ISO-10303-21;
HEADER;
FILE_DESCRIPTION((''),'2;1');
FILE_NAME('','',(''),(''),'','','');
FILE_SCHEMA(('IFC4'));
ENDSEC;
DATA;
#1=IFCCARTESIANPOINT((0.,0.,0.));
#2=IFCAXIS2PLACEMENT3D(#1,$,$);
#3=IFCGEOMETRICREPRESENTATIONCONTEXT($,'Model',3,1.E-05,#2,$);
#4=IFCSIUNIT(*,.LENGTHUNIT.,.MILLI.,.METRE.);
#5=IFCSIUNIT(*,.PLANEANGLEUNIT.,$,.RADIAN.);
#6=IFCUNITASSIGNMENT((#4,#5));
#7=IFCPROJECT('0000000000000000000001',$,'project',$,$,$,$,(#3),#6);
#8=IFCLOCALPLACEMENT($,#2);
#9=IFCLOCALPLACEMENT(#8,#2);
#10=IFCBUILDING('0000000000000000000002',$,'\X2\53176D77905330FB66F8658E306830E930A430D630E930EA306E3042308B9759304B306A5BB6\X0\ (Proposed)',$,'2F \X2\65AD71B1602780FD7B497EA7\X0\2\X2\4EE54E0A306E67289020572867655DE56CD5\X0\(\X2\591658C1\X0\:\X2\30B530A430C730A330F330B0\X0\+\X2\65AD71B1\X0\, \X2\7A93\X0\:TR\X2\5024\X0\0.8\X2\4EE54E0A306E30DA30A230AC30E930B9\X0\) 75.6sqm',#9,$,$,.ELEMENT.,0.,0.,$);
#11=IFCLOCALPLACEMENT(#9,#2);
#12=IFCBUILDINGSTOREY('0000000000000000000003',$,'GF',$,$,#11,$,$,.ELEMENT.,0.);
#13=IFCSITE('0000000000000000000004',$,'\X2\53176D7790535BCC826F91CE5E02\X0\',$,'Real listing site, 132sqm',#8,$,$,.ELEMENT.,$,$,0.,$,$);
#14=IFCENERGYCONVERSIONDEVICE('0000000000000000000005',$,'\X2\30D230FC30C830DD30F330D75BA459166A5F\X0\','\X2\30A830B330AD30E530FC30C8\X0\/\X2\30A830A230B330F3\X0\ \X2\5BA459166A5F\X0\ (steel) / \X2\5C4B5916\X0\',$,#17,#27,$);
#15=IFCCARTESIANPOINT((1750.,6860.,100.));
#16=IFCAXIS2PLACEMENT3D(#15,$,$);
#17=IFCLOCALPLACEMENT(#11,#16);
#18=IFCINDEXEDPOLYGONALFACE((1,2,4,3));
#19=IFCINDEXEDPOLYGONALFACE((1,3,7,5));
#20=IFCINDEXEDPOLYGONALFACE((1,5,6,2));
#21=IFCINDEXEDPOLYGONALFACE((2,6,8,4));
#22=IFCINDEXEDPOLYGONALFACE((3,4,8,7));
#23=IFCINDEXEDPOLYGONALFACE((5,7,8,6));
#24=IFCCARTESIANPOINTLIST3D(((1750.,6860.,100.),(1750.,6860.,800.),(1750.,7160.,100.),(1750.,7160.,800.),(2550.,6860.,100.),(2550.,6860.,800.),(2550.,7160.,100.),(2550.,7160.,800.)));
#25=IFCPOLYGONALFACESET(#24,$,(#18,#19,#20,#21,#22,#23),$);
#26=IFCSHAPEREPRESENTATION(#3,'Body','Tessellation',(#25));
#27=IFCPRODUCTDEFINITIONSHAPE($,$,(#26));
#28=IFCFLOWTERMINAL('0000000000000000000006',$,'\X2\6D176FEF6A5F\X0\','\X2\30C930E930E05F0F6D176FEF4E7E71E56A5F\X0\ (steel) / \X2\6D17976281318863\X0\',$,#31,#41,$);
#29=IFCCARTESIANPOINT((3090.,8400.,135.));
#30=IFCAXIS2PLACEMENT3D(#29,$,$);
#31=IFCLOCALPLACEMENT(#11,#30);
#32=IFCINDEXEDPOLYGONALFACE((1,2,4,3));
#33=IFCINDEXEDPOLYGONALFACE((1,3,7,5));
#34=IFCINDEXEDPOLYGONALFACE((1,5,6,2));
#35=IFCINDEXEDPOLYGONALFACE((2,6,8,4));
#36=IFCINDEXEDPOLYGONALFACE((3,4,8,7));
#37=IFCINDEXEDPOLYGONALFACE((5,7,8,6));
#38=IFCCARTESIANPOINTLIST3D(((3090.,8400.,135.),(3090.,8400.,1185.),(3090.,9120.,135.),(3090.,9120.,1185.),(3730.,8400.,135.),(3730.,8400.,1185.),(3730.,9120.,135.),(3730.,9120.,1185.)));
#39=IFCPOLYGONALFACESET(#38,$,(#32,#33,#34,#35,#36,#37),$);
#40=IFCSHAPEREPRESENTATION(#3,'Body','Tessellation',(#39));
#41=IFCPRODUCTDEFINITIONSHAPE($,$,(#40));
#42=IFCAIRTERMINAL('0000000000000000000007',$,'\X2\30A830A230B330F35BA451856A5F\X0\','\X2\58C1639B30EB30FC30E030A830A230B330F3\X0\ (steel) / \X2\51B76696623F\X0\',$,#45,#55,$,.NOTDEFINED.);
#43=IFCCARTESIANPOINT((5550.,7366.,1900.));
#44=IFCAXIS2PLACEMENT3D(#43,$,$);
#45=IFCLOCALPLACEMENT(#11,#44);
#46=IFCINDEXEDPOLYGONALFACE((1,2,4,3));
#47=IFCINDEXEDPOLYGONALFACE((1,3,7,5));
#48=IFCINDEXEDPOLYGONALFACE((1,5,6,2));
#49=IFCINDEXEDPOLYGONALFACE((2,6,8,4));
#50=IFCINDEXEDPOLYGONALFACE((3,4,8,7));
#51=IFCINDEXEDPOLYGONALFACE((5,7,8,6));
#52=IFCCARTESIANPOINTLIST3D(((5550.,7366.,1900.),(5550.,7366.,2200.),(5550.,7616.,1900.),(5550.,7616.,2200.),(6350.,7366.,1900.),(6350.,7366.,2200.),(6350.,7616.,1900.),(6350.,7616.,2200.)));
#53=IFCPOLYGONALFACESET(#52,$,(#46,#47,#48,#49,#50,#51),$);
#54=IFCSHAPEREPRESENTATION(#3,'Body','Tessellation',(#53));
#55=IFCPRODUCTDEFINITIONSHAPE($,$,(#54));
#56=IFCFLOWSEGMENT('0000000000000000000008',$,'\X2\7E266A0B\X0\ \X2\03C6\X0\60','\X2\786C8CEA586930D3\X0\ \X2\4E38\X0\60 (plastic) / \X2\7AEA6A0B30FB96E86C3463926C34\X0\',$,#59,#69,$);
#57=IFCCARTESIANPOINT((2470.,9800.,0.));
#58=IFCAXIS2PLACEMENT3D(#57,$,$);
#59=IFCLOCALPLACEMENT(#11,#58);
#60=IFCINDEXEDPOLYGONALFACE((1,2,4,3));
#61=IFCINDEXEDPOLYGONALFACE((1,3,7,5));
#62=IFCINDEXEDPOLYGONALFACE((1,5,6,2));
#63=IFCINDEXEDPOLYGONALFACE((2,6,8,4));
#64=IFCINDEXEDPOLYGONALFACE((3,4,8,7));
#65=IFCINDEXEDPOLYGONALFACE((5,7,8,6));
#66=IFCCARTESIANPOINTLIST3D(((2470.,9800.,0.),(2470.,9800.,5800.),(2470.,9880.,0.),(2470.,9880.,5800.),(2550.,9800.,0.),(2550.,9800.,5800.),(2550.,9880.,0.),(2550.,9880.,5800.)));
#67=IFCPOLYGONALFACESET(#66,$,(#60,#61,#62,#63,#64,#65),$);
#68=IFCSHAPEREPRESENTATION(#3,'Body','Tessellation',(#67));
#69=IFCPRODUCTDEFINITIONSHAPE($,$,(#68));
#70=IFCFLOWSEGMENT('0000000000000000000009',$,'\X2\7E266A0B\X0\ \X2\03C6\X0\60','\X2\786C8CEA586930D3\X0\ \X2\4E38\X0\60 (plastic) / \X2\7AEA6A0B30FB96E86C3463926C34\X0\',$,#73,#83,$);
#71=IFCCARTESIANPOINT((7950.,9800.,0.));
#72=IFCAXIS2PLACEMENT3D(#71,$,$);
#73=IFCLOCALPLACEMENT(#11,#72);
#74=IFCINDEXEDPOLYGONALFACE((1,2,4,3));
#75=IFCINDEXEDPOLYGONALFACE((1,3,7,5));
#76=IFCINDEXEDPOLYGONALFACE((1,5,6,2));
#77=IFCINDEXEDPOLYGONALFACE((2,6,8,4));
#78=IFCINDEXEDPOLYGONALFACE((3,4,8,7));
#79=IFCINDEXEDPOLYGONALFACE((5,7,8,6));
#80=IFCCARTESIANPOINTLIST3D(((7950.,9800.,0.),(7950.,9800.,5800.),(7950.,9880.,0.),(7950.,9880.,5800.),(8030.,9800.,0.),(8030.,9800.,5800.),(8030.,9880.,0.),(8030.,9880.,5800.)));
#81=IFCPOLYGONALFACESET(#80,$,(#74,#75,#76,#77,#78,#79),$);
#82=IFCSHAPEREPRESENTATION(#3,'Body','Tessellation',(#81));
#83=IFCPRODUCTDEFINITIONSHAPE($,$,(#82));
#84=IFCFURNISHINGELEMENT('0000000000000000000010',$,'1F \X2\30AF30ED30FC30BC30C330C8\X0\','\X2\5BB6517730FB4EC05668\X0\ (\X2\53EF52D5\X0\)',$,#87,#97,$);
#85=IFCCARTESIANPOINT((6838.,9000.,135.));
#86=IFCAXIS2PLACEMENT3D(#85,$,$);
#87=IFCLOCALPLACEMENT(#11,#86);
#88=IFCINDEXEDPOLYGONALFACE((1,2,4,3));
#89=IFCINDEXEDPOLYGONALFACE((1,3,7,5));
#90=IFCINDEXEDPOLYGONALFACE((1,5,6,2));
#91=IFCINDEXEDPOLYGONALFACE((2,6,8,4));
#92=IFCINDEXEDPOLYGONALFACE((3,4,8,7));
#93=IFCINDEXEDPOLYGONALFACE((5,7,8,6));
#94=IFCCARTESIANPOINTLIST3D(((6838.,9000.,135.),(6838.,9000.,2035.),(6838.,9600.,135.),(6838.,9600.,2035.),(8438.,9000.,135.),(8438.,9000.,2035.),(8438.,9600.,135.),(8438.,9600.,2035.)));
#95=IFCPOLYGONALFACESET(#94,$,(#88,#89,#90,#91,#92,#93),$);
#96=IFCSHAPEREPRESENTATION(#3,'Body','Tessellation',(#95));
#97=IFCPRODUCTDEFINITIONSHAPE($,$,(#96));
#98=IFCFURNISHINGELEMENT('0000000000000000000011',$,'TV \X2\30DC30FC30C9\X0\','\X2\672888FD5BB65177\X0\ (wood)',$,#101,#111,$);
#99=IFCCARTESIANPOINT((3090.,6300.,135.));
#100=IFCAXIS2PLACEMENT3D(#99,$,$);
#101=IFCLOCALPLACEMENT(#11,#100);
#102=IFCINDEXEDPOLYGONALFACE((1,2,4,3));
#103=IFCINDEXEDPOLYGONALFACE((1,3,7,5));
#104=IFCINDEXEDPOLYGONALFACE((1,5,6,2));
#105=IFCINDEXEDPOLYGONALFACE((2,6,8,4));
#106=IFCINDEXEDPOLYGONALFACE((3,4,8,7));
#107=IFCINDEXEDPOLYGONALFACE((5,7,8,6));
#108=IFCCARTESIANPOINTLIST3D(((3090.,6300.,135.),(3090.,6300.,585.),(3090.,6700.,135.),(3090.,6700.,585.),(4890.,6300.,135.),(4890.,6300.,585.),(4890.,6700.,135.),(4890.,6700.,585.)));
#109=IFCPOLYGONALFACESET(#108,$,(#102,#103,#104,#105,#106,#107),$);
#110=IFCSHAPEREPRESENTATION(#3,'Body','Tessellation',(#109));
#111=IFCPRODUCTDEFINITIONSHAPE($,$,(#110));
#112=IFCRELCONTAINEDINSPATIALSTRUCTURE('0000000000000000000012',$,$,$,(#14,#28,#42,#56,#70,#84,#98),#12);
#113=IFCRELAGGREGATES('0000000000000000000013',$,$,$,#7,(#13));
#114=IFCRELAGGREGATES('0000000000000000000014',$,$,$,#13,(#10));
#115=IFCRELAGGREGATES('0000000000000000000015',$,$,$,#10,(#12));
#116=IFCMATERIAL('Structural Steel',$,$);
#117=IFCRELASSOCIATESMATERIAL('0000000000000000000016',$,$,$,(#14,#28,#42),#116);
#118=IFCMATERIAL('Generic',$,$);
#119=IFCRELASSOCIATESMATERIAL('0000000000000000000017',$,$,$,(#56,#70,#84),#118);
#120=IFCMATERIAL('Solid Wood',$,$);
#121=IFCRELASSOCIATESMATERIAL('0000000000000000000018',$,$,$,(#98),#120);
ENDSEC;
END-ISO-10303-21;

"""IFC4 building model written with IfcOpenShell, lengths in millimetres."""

from ifc_helpers import new_model, si_unit, frame, frame_2d, origin, place, context, project, spatial, rectangle, extrude, material, element, save


model = new_model("IFC4")

# Units and contexts
model_context = context("Model", 3, precision=1e-05, world=origin())
ifc_project = project(units=[si_unit("LENGTHUNIT", "METRE", prefix="MILLI"), si_unit("PLANEANGLEUNIT", "RADIAN")], contexts=[model_context])

# Site, building, storey
site_placement = place(None, origin())
site = spatial("IfcSite", under=ifc_project, at=site_placement, Name="北海道富良野市", ObjectType="Real listing site, 132sqm", CompositionType="ELEMENT", RefElevation=0.0)
building_placement = place(site_placement, origin())
building = spatial("IfcBuilding", under=site, at=building_placement, Name="北海道・書斎とライブラリのある静かな家 (Proposed)", ObjectType="2F 断熱性能等级2以上の木造在来工法(外壁:サイディング+断熱, 窓:TR値0.8以上のペアガラス) 75.6sqm", CompositionType="ELEMENT", ElevationOfRefHeight=0.0, ElevationOfTerrain=0.0)
storey_placement = place(building_placement, origin())
storey = spatial("IfcBuildingStorey", under=building, at=storey_placement, Name="GF", CompositionType="ELEMENT", Elevation=0.0)

# Shared definitions
ifc_material_1 = material(Name="Solid Wood")

# Shared definitions
ifc_material_2 = material(Name="Generic")

# Shared definitions
ifc_material_3 = material(Name="Structural Steel")

# Energy conversion device
energy_conversion_device_placement = place(storey_placement, frame((1750.0, 6860.0, 100.0)))
element("IfcEnergyConversionDevice", 1, at=energy_conversion_device_placement, inside=storey, material=ifc_material_3, Name="ヒートポンプ室外機", Description="エコキュート/エアコン 室外機 (steel) / 屋外", context=model_context, shape_type="SweptSolid", body=[
    extrude(rectangle(XDim=800.0, YDim=300.0, at=frame_2d((400.0, 150.0))), frame((1750.0, 6860.0, 100.0)), (0.0, 0.0, 1.0), 700.0),
])

# Flow terminal
flow_terminal_placement = place(storey_placement, frame((3090.0, 8400.0, 135.0)))
element("IfcFlowTerminal", 2, at=flow_terminal_placement, inside=storey, material=ifc_material_3, Name="洗濯機", Description="ドラム式洗濯乾燥機 (steel) / 洗面脱衣", context=model_context, shape_type="SweptSolid", body=[
    extrude(rectangle(XDim=640.0, YDim=720.0, at=frame_2d((320.0, 360.0))), frame((3090.0, 8400.0, 135.0)), (0.0, 0.0, 1.0), 1050.0),
])

# Air terminal
air_terminal_placement = place(storey_placement, frame((5550.0, 7366.0, 1900.0)))
element("IfcAirTerminal", 3, at=air_terminal_placement, inside=storey, material=ifc_material_3, Name="エアコン室内機", Description="壁掛ルームエアコン (steel) / 冷暖房", PredefinedType="NOTDEFINED", context=model_context, shape_type="SweptSolid", body=[
    extrude(rectangle(XDim=800.0, YDim=250.0, at=frame_2d((400.0, 125.0))), frame((5550.0, 7366.0, 1900.0)), (0.0, 0.0, 1.0), 300.0),
])

# Flow segments
flow_segment_1_placement = place(storey_placement, frame((2470.0, 9800.0, 0.0)))
element("IfcFlowSegment", 4, at=flow_segment_1_placement, inside=storey, material=ifc_material_2, Name="縦樋 φ60", Description="硬質塩ビ 丸60 (plastic) / 竪樋・雨水排水", context=model_context, shape_type="SweptSolid", body=[
    extrude(rectangle(XDim=80.0, YDim=80.0, at=frame_2d((40.0, 40.0))), frame((2470.0, 9800.0, 0.0)), (0.0, 0.0, 1.0), 5800.0),
])
flow_segment_2_placement = place(storey_placement, frame((7950.0, 9800.0, 0.0)))
element("IfcFlowSegment", 5, at=flow_segment_2_placement, inside=storey, material=ifc_material_2, Name="縦樋 φ60", Description="硬質塩ビ 丸60 (plastic) / 竪樋・雨水排水", context=model_context, shape_type="SweptSolid", body=[
    extrude(rectangle(XDim=80.0, YDim=80.0, at=frame_2d((40.0, 40.0))), frame((7950.0, 9800.0, 0.0)), (0.0, 0.0, 1.0), 5800.0),
])

# Furnishing elements
furnishing_1_placement = place(storey_placement, frame((6838.0, 9000.0, 135.0)))
element("IfcFurnishingElement", 6, at=furnishing_1_placement, inside=storey, material=ifc_material_2, Name="1F クローゼット", Description="家具・什器 (可動)", context=model_context, shape_type="SweptSolid", body=[
    extrude(rectangle(XDim=1600.0, YDim=600.0, at=frame_2d((800.0, 300.0))), frame((6838.0, 9000.0, 135.0)), (0.0, 0.0, 1.0), 1900.0),
])
furnishing_2_placement = place(storey_placement, frame((3090.0, 6300.0, 135.0)))
element("IfcFurnishingElement", 7, at=furnishing_2_placement, inside=storey, material=ifc_material_1, Name="TV ボード", Description="木製家具 (wood)", context=model_context, shape_type="SweptSolid", body=[
    extrude(rectangle(XDim=1800.0, YDim=400.0, at=frame_2d((900.0, 200.0))), frame((3090.0, 6300.0, 135.0)), (0.0, 0.0, 1.0), 450.0),
])

save(model, "model.ifc")
